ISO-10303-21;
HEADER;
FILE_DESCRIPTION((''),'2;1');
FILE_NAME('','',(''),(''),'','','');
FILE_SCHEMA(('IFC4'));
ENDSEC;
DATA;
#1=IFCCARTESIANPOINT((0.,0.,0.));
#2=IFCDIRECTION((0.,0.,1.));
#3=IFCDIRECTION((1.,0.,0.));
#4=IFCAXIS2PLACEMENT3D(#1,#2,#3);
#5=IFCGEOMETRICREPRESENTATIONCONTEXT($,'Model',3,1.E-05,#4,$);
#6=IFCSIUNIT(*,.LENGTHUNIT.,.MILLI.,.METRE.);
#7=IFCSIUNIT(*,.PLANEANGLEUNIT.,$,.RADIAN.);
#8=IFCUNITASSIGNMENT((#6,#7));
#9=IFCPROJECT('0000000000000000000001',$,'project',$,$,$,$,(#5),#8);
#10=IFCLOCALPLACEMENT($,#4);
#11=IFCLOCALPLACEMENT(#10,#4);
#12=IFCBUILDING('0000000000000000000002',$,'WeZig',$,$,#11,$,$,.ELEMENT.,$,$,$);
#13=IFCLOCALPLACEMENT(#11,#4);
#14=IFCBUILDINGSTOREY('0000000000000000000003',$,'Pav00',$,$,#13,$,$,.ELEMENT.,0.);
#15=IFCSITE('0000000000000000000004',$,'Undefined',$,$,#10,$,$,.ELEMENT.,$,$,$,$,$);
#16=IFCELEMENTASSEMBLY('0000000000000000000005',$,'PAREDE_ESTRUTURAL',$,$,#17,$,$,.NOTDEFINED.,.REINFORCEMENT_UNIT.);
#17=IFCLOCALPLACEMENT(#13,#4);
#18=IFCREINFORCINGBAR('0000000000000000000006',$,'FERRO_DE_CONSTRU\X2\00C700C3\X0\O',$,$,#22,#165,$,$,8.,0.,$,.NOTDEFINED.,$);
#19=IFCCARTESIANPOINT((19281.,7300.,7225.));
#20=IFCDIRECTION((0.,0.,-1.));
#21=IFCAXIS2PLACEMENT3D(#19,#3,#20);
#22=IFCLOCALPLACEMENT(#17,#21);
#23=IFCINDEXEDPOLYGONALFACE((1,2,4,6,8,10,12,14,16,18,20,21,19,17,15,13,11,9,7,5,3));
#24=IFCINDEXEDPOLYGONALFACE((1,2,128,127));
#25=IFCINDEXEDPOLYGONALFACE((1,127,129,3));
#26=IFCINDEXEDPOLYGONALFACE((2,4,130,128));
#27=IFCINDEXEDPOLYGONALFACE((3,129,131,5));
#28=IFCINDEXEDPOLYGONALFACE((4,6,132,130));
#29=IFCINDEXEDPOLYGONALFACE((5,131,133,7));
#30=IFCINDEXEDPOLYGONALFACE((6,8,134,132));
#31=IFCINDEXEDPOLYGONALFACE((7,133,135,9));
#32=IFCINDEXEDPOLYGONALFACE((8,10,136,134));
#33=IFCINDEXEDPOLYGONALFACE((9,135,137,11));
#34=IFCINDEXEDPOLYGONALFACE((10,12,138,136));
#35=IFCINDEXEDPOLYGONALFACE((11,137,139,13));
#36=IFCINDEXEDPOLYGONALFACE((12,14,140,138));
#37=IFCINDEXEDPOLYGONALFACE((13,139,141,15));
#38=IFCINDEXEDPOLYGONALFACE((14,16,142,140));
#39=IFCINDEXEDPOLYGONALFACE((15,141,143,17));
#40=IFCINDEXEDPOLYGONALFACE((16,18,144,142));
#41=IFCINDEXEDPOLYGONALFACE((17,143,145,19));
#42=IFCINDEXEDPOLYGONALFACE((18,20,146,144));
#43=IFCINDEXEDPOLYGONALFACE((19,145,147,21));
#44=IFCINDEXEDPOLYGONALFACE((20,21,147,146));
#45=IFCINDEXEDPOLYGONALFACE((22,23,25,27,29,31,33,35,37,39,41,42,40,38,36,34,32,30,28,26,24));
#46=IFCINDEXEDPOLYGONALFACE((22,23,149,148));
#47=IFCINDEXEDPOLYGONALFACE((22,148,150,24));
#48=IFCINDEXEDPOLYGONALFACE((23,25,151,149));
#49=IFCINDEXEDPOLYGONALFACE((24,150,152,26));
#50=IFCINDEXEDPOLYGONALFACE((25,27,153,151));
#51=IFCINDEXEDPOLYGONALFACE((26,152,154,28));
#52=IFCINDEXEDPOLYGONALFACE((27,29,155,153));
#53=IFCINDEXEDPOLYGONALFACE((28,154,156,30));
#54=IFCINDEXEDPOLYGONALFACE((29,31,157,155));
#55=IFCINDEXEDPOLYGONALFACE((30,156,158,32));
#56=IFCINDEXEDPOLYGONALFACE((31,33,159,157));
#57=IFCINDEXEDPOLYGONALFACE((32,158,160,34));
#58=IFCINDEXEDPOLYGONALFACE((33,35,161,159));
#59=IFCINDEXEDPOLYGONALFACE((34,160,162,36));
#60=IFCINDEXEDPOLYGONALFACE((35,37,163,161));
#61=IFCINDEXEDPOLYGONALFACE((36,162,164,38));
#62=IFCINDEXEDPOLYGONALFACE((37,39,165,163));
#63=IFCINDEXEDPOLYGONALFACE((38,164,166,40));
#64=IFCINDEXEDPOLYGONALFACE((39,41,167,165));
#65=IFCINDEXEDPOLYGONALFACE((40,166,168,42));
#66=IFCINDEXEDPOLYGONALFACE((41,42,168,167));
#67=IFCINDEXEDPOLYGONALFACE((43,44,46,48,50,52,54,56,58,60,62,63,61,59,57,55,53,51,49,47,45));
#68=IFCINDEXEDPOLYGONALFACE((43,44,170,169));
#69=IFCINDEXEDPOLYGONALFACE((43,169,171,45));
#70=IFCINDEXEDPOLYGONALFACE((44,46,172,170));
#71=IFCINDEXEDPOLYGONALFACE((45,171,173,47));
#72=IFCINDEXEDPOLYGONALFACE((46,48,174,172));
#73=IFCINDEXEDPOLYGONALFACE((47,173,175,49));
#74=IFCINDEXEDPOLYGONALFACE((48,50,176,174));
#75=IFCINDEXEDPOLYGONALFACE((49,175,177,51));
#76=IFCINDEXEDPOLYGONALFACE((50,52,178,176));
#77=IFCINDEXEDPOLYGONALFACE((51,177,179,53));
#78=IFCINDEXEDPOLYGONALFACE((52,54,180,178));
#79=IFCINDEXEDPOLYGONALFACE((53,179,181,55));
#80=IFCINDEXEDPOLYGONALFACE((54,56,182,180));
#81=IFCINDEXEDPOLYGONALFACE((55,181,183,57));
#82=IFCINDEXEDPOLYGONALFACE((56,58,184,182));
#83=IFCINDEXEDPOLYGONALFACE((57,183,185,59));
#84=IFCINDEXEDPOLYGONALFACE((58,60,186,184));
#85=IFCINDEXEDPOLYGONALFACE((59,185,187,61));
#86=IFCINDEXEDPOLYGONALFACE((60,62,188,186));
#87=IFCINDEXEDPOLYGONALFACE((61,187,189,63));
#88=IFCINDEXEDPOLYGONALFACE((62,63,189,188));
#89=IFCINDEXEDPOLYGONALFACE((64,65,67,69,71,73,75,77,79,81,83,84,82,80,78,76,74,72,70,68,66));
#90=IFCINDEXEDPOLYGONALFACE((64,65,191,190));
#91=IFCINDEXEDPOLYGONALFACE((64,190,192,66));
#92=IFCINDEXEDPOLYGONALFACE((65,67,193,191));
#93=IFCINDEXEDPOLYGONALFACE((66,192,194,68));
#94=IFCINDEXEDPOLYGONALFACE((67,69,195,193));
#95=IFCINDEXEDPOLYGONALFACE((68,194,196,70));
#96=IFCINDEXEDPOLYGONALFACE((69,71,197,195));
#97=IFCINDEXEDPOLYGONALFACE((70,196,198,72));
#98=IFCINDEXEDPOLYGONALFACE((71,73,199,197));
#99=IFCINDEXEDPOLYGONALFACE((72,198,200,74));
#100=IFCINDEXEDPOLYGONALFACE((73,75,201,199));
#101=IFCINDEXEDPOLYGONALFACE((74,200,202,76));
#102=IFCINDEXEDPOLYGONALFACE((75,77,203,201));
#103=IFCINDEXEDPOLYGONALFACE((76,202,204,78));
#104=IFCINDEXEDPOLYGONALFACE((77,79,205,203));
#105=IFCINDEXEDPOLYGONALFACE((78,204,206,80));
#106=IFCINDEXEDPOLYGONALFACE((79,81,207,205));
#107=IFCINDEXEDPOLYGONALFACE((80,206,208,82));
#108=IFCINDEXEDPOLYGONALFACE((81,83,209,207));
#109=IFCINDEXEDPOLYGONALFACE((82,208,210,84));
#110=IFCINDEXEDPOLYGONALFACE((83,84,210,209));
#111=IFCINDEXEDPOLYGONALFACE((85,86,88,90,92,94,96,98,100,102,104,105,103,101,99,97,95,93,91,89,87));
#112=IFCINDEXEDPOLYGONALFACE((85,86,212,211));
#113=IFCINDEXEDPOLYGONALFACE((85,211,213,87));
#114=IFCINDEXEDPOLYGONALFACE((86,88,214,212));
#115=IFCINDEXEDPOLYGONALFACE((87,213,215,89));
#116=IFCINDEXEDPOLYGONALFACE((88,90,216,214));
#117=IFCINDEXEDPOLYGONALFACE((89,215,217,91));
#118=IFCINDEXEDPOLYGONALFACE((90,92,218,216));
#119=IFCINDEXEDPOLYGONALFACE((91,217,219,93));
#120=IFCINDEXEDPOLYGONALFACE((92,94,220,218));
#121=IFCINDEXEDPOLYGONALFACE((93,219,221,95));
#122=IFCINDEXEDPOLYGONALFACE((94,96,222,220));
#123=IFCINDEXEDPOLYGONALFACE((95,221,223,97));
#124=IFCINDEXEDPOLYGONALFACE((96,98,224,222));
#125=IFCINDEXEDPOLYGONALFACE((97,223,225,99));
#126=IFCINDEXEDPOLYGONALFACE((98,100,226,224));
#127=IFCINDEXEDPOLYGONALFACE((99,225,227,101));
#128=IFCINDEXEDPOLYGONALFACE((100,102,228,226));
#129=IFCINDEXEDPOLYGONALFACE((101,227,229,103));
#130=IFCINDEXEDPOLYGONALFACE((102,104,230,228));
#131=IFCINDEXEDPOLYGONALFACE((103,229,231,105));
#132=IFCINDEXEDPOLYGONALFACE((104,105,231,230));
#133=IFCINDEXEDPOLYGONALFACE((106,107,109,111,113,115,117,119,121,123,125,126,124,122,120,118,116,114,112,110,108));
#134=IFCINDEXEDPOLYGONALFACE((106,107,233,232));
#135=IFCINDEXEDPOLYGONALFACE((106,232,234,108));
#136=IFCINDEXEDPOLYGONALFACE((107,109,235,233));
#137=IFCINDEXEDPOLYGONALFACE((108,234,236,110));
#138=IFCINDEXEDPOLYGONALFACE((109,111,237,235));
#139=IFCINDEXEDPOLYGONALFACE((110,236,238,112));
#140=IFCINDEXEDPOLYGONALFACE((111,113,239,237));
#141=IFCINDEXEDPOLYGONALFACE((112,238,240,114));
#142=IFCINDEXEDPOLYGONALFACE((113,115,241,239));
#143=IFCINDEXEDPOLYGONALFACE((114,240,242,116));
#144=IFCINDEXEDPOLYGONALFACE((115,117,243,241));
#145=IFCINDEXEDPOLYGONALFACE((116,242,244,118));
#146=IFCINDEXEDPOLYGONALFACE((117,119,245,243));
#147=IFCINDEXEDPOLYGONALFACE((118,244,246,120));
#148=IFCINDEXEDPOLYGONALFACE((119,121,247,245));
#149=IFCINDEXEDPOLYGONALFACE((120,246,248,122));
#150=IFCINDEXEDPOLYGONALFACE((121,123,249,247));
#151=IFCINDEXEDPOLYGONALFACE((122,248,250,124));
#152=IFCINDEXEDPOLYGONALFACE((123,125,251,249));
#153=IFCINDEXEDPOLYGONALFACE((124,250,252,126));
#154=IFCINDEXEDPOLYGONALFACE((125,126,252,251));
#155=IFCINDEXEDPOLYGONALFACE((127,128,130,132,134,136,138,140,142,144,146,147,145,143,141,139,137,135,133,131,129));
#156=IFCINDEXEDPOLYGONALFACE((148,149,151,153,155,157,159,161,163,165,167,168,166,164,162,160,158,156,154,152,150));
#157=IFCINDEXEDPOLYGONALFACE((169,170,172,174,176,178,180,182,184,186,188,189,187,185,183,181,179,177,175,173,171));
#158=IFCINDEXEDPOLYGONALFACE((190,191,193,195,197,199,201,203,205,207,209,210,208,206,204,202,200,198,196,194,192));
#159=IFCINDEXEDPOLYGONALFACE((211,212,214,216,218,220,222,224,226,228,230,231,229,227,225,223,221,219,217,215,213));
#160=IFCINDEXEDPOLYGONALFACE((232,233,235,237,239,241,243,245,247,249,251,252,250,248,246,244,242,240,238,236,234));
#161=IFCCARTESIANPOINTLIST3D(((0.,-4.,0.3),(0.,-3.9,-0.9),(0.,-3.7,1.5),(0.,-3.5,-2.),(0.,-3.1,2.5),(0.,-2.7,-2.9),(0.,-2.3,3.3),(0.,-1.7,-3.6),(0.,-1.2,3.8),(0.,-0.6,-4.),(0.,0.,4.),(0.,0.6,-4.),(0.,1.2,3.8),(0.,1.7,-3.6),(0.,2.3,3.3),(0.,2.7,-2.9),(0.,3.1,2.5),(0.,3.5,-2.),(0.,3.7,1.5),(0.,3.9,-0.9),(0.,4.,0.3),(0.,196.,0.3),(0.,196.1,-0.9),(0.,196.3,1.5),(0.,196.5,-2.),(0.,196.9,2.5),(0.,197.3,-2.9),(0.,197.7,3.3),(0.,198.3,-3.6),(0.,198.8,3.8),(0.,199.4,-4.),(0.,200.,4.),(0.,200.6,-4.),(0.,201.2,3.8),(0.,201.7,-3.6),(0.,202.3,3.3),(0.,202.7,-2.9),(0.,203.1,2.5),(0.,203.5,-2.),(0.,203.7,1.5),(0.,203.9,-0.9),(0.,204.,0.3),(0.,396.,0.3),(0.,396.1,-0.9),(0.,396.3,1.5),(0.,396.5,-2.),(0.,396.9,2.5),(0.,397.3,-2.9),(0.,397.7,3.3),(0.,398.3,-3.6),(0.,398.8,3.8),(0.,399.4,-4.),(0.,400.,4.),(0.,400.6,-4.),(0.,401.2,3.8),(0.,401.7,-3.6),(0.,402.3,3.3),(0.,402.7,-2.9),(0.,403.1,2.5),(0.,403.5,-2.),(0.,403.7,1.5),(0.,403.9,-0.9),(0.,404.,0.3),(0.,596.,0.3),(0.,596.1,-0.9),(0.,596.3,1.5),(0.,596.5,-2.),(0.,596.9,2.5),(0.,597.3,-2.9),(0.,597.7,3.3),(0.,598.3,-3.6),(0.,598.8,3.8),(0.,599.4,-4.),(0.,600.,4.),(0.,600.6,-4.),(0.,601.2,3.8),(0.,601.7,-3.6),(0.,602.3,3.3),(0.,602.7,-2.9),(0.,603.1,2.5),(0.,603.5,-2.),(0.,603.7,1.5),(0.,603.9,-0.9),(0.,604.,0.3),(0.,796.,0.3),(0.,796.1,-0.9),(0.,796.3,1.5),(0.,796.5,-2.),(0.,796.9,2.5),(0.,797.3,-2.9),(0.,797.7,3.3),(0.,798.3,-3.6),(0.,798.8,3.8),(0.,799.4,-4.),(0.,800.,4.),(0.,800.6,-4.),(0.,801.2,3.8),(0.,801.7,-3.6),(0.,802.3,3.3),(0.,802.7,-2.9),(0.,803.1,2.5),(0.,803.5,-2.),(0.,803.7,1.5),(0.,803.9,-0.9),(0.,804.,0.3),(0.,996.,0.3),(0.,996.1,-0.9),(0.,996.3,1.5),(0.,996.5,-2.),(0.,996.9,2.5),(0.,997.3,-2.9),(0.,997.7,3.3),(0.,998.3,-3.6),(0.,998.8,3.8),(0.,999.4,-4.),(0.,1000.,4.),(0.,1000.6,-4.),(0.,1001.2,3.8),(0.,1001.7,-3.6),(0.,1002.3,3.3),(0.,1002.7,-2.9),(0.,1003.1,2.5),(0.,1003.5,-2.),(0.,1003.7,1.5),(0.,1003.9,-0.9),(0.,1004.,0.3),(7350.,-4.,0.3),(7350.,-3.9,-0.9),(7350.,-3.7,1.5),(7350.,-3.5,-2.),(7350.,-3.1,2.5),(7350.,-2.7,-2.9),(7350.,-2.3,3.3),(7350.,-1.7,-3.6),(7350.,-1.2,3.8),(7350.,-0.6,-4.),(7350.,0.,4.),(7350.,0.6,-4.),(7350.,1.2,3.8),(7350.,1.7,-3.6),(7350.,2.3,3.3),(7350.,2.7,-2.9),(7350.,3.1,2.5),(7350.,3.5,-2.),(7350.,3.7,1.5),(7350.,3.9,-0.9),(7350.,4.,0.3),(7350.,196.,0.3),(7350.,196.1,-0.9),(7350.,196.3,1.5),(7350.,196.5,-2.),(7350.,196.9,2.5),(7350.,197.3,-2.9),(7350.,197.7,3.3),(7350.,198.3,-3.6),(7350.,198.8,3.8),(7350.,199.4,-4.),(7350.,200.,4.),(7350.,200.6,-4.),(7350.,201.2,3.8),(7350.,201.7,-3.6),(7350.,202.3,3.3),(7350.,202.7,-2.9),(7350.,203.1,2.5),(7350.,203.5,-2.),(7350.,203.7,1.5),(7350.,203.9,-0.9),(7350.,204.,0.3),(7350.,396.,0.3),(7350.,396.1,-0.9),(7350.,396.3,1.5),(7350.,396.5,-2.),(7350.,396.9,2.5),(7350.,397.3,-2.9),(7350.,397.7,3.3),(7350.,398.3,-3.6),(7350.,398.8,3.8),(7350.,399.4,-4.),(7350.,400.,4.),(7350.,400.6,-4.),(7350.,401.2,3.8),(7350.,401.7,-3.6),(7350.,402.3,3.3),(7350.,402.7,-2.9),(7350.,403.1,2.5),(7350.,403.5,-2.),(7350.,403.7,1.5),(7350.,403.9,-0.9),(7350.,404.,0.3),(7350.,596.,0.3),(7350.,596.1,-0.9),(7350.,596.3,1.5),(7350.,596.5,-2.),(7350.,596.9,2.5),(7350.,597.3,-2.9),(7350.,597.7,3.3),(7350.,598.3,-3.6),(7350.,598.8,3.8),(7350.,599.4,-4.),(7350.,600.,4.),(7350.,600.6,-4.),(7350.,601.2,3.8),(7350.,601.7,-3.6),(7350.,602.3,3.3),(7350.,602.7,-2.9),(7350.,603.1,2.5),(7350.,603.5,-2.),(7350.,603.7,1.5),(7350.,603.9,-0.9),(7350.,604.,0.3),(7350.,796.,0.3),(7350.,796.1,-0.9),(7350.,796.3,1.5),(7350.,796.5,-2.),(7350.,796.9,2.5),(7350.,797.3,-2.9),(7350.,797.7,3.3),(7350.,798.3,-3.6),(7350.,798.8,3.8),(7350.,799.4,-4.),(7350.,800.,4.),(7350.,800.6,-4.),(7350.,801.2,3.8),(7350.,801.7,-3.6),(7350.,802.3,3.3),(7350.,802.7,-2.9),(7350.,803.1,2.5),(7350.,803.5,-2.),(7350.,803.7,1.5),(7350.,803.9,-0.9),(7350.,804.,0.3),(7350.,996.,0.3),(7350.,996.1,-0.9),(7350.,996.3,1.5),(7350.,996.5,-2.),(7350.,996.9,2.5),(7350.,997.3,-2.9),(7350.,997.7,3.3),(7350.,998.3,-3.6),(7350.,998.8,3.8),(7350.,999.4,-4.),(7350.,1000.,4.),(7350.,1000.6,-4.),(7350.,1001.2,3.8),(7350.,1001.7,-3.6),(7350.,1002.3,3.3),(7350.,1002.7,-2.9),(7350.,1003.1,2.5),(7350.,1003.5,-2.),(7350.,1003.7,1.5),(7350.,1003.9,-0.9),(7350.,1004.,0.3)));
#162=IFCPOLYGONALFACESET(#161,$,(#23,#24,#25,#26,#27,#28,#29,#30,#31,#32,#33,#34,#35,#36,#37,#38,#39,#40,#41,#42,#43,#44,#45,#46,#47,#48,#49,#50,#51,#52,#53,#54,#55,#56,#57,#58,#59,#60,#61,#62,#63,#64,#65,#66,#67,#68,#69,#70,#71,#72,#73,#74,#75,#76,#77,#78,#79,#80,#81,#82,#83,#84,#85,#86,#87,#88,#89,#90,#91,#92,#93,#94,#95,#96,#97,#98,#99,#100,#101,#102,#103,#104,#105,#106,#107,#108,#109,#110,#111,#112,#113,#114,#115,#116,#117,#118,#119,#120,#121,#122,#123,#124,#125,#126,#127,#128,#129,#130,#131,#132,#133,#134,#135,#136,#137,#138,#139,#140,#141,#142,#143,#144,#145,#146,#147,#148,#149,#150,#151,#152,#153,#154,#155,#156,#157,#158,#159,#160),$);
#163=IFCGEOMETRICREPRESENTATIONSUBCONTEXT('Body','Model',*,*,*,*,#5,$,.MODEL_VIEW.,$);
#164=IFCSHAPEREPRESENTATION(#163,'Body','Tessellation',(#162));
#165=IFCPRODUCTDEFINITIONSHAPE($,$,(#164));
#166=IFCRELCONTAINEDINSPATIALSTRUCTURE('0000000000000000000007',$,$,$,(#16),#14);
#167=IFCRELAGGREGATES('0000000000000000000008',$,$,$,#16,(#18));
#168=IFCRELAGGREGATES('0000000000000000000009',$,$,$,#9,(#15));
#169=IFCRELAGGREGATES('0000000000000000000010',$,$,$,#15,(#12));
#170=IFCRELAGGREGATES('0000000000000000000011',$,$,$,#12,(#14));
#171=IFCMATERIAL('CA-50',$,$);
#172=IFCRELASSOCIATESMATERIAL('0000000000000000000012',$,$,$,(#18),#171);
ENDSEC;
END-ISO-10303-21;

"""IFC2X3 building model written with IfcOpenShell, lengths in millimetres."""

from ifc_helpers import new_model, entity, si_unit, frame, origin_with_axes, place, context, subcontext, project, spatial, source, transform, mapped, material, element, aggregate, save


model = new_model("IFC2X3")

# Units and contexts
model_context = context("Model", 3, precision=1e-05, world=origin_with_axes())
body_context = subcontext(model_context, "Body", "Model", "MODEL_VIEW")
ifc_project = project(units=[si_unit("LENGTHUNIT", "METRE", prefix="MILLI"), si_unit("PLANEANGLEUNIT", "RADIAN")], contexts=[model_context])

# Site, building, storey
site_placement = place(None, origin_with_axes())
site = spatial("IfcSite", under=ifc_project, at=site_placement, Name="Undefined", CompositionType="ELEMENT")
building_placement = place(site_placement, origin_with_axes())
building = spatial("IfcBuilding", under=site, at=building_placement, Name="WeZig", CompositionType="ELEMENT")
storey_placement = place(building_placement, origin_with_axes())
storey = spatial("IfcBuildingStorey", under=building, at=storey_placement, Name="Pav00", CompositionType="ELEMENT", Elevation=0.0)

# Shared definitions
ifc_material_1 = material(Name="CA-50")

# Element assembly, reinforcing bar
assembly_1_placement = place(storey_placement, origin_with_axes())
assembly_1 = element("IfcElementAssembly", 1, at=assembly_1_placement, inside=storey, Name="PAREDE_ESTRUTURAL", AssemblyPlace="NOTDEFINED", PredefinedType="REINFORCEMENT_UNIT")
shared_shape_1 = source(origin_with_axes(), body_context, "Body", "AdvancedSweptSolid", [
    entity("IfcSweptDiskSolid", entity("IfcTrimmedCurve", entity("IfcLine", entity("IfcCartesianPoint", [0.0, 0.0, 0.0]), entity("IfcVector", entity("IfcDirection", [1.0, 0.0, 0.0]), 1.0)), [entity("IfcParameterValue", 0.0)], [entity("IfcParameterValue", 7350.0)], True, "PARAMETER"), 4.0, None, 0.0, 7350.0),
])
shared_shape_2 = source(origin_with_axes(), body_context, "Body", "AdvancedSweptSolid", [
    entity("IfcSweptDiskSolid", entity("IfcTrimmedCurve", entity("IfcLine", entity("IfcCartesianPoint", [0.0, 0.0, 0.0]), entity("IfcVector", entity("IfcDirection", [1.0, 0.0, 0.0]), 1.0)), [entity("IfcParameterValue", 0.0)], [entity("IfcParameterValue", 7350.0)], True, "PARAMETER"), 4.0, None, 0.0, 7350.0),
])
shared_shape_3 = source(origin_with_axes(), body_context, "Body", "AdvancedSweptSolid", [
    entity("IfcSweptDiskSolid", entity("IfcTrimmedCurve", entity("IfcLine", entity("IfcCartesianPoint", [0.0, 0.0, 0.0]), entity("IfcVector", entity("IfcDirection", [1.0, 0.0, 0.0]), 1.0)), [entity("IfcParameterValue", 0.0)], [entity("IfcParameterValue", 7350.0)], True, "PARAMETER"), 4.0, None, 0.0, 7350.0),
])
shared_shape_4 = source(origin_with_axes(), body_context, "Body", "AdvancedSweptSolid", [
    entity("IfcSweptDiskSolid", entity("IfcTrimmedCurve", entity("IfcLine", entity("IfcCartesianPoint", [0.0, 0.0, 0.0]), entity("IfcVector", entity("IfcDirection", [1.0, 0.0, 0.0]), 1.0)), [entity("IfcParameterValue", 0.0)], [entity("IfcParameterValue", 7350.0)], True, "PARAMETER"), 4.0, None, 0.0, 7350.0),
])
shared_shape_5 = source(origin_with_axes(), body_context, "Body", "AdvancedSweptSolid", [
    entity("IfcSweptDiskSolid", entity("IfcTrimmedCurve", entity("IfcLine", entity("IfcCartesianPoint", [0.0, 0.0, 0.0]), entity("IfcVector", entity("IfcDirection", [1.0, 0.0, 0.0]), 1.0)), [entity("IfcParameterValue", 0.0)], [entity("IfcParameterValue", 7350.0)], True, "PARAMETER"), 4.0, None, 0.0, 7350.0),
])
shared_shape_6 = source(origin_with_axes(), body_context, "Body", "AdvancedSweptSolid", [
    entity("IfcSweptDiskSolid", entity("IfcTrimmedCurve", entity("IfcLine", entity("IfcCartesianPoint", [0.0, 0.0, 0.0]), entity("IfcVector", entity("IfcDirection", [1.0, 0.0, 0.0]), 1.0)), [entity("IfcParameterValue", 0.0)], [entity("IfcParameterValue", 7350.0)], True, "PARAMETER"), 4.0, None, 0.0, 7350.0),
])
reinforcing_bar_1_placement = place(assembly_1_placement, frame((19281.0, 7300.0, 7225.0), z_axis=(1.0, 0.0, 0.0), x_axis=(0.0, 0.0, -1.0)))
reinforcing_bar_1 = element("IfcReinforcingBar", 2, at=reinforcing_bar_1_placement, material=ifc_material_1, Name="FERRO_DE_CONSTRUÇÃO", BarRole="NOTDEFINED", CrossSectionArea=0.0, NominalDiameter=8.0, context=body_context, shape_type="MappedRepresentation", body=[
    mapped(shared_shape_1, transform((0.0, 0.0, 0.0))),
    mapped(shared_shape_2, transform((0.0, 200.0, 0.0))),
    mapped(shared_shape_3, transform((0.0, 400.0, 0.0))),
    mapped(shared_shape_4, transform((0.0, 600.0, 0.0))),
    mapped(shared_shape_5, transform((0.0, 800.0, 0.0))),
    mapped(shared_shape_6, transform((0.0, 1000.0, 0.0))),
])
aggregate(assembly_1, [reinforcing_bar_1])

save(model, "model.ifc")
